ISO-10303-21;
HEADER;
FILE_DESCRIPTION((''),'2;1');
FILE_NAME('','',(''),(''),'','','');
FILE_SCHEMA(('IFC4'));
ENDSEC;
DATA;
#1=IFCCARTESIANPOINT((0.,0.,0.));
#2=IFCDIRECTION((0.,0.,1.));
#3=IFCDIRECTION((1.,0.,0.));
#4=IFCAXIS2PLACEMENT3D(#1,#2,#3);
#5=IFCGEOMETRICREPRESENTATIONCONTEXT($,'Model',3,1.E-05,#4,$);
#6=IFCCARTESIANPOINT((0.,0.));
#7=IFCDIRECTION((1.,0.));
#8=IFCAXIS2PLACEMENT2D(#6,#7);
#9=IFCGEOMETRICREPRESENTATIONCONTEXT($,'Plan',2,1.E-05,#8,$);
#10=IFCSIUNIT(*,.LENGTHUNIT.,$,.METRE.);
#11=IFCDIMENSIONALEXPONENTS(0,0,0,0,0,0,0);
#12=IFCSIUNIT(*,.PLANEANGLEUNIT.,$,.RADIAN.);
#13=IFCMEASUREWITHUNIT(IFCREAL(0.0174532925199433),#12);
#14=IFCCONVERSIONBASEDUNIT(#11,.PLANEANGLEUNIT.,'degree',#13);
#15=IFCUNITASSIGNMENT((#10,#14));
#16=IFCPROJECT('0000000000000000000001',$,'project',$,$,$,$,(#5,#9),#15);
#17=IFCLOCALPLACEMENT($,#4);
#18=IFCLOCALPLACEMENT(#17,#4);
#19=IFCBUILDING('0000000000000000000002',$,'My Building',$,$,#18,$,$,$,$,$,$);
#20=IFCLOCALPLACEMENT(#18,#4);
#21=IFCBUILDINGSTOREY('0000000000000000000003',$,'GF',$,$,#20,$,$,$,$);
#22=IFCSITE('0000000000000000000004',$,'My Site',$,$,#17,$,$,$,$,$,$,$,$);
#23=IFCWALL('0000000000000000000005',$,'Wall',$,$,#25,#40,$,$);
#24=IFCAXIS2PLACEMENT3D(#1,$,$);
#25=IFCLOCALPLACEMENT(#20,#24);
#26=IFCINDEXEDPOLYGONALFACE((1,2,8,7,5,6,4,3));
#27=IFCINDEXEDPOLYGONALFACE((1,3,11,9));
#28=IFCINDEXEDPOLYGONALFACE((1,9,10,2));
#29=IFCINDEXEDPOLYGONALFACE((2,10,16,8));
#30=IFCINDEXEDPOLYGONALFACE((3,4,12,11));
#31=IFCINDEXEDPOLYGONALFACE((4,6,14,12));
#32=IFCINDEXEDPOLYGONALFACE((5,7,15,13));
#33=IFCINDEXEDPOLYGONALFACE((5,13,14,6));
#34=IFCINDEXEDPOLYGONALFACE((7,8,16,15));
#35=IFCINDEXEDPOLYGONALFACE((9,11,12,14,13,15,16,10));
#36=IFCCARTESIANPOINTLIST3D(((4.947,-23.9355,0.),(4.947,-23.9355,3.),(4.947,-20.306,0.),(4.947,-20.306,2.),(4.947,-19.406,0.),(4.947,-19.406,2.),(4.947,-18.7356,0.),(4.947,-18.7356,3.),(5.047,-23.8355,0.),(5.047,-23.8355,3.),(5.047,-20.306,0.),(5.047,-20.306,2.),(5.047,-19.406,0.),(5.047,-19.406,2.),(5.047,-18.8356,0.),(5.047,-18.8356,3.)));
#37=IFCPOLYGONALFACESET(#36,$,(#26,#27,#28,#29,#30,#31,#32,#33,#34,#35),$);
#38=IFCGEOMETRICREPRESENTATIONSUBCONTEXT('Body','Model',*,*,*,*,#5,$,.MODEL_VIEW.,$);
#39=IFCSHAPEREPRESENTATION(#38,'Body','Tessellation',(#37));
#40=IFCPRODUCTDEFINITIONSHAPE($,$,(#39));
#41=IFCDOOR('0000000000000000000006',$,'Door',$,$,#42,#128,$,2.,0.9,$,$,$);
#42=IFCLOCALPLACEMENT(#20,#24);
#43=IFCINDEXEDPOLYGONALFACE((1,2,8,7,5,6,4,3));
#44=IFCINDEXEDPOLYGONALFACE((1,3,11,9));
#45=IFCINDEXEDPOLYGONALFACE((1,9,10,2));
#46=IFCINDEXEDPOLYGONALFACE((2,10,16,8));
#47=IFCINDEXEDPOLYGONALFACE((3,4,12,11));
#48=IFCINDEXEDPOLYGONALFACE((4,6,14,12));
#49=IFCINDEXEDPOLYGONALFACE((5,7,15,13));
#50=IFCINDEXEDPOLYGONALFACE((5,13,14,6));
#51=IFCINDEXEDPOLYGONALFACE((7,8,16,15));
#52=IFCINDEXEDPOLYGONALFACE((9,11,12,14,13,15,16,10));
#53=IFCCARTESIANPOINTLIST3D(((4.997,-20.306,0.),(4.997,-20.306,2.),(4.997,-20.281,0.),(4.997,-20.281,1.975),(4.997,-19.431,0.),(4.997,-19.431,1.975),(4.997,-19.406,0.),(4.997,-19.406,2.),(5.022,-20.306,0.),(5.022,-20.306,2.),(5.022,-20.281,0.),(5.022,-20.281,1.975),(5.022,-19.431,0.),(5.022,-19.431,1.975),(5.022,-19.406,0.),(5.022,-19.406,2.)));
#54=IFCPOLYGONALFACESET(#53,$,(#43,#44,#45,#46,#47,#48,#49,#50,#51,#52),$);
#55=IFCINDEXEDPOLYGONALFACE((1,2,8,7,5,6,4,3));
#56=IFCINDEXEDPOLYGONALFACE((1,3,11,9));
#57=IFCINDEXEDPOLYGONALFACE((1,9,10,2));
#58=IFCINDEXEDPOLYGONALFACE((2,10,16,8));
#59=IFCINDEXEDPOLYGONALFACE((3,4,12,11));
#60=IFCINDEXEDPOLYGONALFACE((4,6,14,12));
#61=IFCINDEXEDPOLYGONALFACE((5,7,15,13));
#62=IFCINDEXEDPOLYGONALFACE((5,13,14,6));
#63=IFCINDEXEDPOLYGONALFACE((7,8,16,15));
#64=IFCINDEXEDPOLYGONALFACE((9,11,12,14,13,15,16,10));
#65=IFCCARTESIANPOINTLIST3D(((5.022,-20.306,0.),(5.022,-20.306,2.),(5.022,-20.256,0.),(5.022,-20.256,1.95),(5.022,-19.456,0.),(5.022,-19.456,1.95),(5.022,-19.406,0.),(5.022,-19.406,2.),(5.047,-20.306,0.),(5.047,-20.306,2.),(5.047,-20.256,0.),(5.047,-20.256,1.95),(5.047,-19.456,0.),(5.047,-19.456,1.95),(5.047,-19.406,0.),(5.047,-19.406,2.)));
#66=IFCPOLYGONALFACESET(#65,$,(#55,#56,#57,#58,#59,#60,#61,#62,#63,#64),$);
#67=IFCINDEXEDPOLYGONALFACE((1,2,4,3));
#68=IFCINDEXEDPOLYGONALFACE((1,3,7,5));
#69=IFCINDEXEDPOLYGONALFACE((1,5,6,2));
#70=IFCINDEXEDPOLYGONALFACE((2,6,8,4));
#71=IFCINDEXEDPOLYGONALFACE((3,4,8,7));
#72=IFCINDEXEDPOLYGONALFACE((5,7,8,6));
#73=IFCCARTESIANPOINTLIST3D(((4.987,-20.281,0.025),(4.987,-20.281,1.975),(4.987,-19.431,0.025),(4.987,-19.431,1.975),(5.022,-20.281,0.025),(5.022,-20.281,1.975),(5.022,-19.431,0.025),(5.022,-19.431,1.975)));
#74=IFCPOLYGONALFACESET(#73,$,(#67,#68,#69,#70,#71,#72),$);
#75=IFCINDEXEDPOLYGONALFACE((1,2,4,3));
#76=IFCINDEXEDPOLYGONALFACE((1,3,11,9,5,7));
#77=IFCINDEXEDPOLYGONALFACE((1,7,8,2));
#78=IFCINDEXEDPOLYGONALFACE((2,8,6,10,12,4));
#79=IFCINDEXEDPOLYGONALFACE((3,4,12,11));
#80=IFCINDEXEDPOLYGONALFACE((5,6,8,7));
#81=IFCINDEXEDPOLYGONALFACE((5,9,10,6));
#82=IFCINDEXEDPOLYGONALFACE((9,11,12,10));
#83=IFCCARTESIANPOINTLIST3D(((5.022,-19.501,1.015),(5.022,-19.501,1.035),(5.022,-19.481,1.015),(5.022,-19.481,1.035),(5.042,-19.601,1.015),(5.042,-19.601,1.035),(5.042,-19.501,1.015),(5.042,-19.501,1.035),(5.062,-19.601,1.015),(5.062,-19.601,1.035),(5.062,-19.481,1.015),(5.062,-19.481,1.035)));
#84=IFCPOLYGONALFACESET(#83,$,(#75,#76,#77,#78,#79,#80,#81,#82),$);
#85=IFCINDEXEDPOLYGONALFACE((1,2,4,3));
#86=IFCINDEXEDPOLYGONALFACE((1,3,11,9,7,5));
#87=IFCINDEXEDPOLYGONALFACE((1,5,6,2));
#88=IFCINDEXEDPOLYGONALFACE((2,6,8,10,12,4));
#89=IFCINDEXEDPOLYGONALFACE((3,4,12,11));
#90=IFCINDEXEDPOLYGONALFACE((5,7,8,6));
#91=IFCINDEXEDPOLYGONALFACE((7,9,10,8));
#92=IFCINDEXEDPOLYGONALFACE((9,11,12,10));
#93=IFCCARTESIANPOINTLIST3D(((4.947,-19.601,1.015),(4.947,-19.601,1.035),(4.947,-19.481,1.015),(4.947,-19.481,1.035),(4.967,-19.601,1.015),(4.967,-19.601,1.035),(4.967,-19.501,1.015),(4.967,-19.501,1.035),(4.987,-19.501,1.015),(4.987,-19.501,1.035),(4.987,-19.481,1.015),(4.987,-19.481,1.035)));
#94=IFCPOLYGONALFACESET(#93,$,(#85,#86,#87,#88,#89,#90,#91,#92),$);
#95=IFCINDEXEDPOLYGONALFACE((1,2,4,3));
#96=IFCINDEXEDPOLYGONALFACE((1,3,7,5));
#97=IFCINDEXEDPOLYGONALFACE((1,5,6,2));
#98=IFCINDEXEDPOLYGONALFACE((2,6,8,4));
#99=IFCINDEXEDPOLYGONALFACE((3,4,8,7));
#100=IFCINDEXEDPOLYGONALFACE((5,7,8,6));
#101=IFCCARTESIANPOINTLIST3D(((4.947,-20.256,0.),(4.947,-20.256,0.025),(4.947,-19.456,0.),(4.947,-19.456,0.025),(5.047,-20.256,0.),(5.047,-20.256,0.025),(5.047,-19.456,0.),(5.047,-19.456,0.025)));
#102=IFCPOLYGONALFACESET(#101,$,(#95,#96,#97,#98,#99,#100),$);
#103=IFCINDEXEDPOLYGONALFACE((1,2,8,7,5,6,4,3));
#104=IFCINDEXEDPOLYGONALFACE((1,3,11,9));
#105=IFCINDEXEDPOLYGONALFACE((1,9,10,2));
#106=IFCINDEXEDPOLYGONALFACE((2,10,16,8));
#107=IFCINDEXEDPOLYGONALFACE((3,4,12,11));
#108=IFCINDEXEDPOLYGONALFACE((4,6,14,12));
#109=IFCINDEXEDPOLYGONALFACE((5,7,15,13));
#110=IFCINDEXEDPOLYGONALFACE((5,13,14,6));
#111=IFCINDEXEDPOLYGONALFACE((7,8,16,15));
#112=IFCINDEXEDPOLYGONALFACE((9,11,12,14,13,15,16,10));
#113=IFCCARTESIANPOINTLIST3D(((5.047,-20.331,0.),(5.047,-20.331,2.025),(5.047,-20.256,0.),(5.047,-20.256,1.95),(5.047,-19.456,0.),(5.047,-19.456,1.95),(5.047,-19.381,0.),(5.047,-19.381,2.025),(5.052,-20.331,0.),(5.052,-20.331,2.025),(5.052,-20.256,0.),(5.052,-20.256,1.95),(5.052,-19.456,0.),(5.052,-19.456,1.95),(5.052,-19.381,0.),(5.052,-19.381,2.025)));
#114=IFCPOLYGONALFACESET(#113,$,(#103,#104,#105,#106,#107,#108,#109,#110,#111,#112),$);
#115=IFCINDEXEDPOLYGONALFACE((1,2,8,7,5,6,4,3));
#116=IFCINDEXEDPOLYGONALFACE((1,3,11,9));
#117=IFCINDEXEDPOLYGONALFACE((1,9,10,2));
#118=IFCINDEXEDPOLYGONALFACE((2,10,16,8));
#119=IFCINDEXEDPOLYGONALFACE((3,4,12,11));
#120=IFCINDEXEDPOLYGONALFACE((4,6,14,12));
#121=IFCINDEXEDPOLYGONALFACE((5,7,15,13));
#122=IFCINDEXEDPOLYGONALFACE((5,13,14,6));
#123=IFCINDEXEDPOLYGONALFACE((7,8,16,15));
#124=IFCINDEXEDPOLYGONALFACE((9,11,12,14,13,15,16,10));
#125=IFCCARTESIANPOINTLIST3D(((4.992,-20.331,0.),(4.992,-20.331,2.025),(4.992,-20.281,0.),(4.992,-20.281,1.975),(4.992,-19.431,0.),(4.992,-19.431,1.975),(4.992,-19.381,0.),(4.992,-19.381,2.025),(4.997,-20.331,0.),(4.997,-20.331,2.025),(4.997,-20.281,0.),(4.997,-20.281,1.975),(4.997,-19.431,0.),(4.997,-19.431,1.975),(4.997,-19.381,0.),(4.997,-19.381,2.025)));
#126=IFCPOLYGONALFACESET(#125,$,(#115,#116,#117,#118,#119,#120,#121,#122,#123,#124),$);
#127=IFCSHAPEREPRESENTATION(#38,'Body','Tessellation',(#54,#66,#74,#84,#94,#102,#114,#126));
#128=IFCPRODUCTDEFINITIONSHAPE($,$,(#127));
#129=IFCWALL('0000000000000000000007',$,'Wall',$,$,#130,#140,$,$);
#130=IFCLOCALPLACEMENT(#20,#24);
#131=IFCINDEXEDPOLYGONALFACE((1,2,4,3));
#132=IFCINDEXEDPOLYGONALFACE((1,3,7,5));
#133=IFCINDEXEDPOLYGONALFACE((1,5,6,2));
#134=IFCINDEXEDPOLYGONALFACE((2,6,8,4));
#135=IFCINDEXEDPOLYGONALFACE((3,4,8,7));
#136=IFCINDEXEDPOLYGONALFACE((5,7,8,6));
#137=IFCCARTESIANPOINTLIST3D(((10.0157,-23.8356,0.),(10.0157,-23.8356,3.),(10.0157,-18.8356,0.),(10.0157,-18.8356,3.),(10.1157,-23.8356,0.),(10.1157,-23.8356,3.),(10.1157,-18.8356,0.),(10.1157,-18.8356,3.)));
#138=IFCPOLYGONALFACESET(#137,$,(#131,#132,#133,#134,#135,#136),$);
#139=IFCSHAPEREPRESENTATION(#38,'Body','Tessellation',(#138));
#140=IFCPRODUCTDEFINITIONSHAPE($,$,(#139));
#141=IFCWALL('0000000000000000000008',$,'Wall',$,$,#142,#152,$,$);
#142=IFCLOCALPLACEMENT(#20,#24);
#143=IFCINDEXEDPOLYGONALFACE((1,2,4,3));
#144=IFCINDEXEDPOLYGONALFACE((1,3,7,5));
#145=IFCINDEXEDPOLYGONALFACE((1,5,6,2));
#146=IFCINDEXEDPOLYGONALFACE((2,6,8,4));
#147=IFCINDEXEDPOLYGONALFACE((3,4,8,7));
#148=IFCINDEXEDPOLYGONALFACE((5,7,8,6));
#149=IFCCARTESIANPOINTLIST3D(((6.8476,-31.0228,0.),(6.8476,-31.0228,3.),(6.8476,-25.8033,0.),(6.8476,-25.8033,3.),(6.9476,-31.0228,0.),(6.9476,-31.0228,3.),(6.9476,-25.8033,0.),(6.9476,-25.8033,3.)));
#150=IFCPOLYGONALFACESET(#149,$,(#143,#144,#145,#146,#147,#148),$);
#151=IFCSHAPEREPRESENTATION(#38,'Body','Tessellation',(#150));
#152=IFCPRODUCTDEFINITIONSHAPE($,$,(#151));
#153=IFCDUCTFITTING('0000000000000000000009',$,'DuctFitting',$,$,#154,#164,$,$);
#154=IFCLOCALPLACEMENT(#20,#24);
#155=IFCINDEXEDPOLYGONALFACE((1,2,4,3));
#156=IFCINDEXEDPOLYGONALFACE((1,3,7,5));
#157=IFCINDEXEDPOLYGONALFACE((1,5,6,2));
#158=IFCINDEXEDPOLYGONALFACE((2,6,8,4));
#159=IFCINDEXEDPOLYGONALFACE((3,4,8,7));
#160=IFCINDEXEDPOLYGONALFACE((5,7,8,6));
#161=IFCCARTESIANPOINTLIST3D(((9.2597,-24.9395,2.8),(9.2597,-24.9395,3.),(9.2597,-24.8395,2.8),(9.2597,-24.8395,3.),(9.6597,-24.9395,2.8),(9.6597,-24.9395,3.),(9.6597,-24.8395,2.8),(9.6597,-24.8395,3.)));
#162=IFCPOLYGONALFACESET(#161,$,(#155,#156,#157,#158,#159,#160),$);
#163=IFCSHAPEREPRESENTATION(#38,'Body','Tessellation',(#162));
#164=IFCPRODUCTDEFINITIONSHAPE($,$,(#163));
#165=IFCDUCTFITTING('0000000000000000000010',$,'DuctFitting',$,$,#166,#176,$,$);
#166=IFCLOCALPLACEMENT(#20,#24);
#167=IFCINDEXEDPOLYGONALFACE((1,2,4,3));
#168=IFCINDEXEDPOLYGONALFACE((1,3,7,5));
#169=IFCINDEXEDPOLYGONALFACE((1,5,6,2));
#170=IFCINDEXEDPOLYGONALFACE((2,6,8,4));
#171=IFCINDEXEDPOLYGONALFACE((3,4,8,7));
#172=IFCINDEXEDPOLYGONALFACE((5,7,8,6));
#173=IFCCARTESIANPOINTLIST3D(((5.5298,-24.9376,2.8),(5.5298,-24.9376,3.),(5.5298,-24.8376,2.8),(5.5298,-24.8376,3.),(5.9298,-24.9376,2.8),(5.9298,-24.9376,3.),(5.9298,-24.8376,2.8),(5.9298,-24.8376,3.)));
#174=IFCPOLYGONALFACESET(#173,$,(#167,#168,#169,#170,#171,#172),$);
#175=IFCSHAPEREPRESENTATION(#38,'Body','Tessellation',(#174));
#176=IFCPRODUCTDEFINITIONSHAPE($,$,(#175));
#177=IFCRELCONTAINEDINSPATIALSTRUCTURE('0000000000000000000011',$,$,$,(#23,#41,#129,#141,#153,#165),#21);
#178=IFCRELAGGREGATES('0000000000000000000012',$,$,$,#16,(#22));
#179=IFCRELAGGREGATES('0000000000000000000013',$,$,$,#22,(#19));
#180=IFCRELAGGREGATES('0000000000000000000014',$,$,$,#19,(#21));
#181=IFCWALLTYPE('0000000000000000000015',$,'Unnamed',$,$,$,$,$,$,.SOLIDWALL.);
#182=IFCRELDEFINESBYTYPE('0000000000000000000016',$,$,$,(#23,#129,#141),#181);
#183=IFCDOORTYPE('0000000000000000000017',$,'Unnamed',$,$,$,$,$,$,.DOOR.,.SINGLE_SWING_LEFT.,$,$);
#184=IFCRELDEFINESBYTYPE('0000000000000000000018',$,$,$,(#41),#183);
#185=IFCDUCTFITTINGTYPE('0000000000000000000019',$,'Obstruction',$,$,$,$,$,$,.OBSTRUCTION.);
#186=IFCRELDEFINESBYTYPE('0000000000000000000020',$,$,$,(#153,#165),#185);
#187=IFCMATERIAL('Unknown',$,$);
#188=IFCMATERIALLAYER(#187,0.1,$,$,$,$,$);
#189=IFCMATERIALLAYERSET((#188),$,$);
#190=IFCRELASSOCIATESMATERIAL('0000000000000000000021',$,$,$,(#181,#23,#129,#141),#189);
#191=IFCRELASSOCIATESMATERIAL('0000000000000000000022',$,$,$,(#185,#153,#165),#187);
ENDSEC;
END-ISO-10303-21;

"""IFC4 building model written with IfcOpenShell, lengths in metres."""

from ifc_helpers import new_model, entity, si_unit, converted_unit, frame, origin_with_axes, origin_2d_with_axis, place, context, subcontext, project, spatial, line, indexed_curve, rectangle, outline, extrude, shape, source, transform, mapped, material, layer, layer_set, layer_usage, material_profile, profile_set, profile_usage, type_object, type_shapes, element, fill, save


model = new_model("IFC4")

# Units and contexts
model_context = context("Model", 3, precision=1e-05, world=origin_with_axes())
plan_context = context("Plan", 2, precision=1e-05, world=origin_2d_with_axis())
body_context_1 = subcontext(model_context, "Body", "Model", "MODEL_VIEW")
body_context_2 = subcontext(plan_context, "Body", "Plan", "PLAN_VIEW")
ifc_project = project(units=[si_unit("LENGTHUNIT", "METRE"), converted_unit("PLANEANGLEUNIT", "degree", entity("IfcReal", 0.0174532925199433), si_unit("PLANEANGLEUNIT", "RADIAN"), dimensions=[0, 0, 0, 0, 0, 0, 0])], contexts=[model_context, plan_context])

# Site, building, storey
site_placement = place(None, origin_with_axes())
site = spatial("IfcSite", under=ifc_project, at=site_placement, Name="My Site")
building_placement = place(site_placement, origin_with_axes())
building = spatial("IfcBuilding", under=site, at=building_placement, Name="My Building")
storey_placement = place(building_placement, origin_with_axes())
storey = spatial("IfcBuildingStorey", under=building, at=storey_placement, Name="GF")

# Shared definitions
ifc_material = material(Name="Unknown")

# Shared definitions
ifc_layer_1 = layer(ifc_material, 0.1)
ifc_layer_set_1 = layer_set([ifc_layer_1])
wall_type = type_object("IfcWallType", Name="Unnamed", PredefinedType="SOLIDWALL", material=ifc_layer_set_1)

# Shared definitions
shared_shape_1 = source(origin_with_axes(), body_context_1, "Body", "SweptSolid", [
    extrude(outline(indexed_curve([(0.0, 0.0), (0.9, 0.0), (0.9, 2.0), (0.0, 2.0)], segments=[line(1, 2, 3, 4, 1)])), frame((0.0, -0.6, 0.0), z_axis=(0.0, -1.0, 0.0), x_axis=(1.0, 0.0, 0.0)), (0.0, 0.0, -1.0), 1.2),
])
door_type = type_object("IfcDoorType", Name="Unnamed", OperationType="SINGLE_SWING_LEFT", PredefinedType="DOOR")
shared_shape_2 = source(origin_with_axes(), body_context_1, "Body", "SweptSolid", [
    extrude(outline(indexed_curve([(0.0, 0.0), (0.0, 2.0), (0.9, 2.0), (0.9, 0.0), (0.875, 0.0), (0.875, 1.975), (0.025, 1.975), (0.025, 0.0)], segments=[line(1, 2, 3, 4, 5, 6, 7, 8, 1)])), frame((0.0, 0.025, 0.0), z_axis=(0.0, -1.0, 0.0), x_axis=(1.0, 0.0, 0.0)), (0.0, 0.0, -1.0), 0.025),
    extrude(outline(indexed_curve([(0.0, 0.0), (0.0, 2.0), (0.9, 2.0), (0.9, 0.0), (0.85, 0.0), (0.85, 1.95), (0.05, 1.95), (0.05, 0.0)], segments=[line(1, 2, 3, 4, 5, 6, 7, 8, 1)])), frame((0.0, 0.0, 0.0), z_axis=(0.0, -1.0, 0.0), x_axis=(1.0, 0.0, 0.0)), (0.0, 0.0, -1.0), 0.025),
    extrude(outline(indexed_curve([(0.0, 0.0), (0.85, 0.0), (0.85, 0.035), (0.0, 0.035)], segments=[line(1, 2, 3, 4, 1)])), frame((0.025, 0.025, 0.025), z_axis=(0.0, 0.0, 1.0), x_axis=(1.0, 0.0, 0.0)), (0.0, 0.0, 1.0), 1.95),
    extrude(outline(indexed_curve([(0.0, 0.0), (0.0, -0.04), (-0.12, -0.04), (-0.12, -0.02), (-0.02, -0.02), (-0.02, 0.0)], segments=[line(1, 2, 3, 4, 5, 6, 1)])), frame((0.825, 0.025, 1.015), z_axis=(0.0, 0.0, 1.0), x_axis=(1.0, 0.0, 0.0)), (0.0, 0.0, 1.0), 0.02),
    extrude(outline(indexed_curve([(0.0, 0.0), (0.0, 0.04), (-0.12, 0.04), (-0.12, 0.02), (-0.02, 0.02), (-0.02, 0.0)], segments=[line(1, 2, 3, 4, 5, 6, 1)])), frame((0.825, 0.06, 1.015), z_axis=(0.0, 0.0, 1.0), x_axis=(1.0, 0.0, 0.0)), (0.0, 0.0, 1.0), 0.02),
    extrude(outline(indexed_curve([(0.0, 0.0), (0.8, 0.0), (0.8, 0.1), (0.0, 0.1)], segments=[line(1, 2, 3, 4, 1)])), frame((0.05, 0.0, 0.0), z_axis=(0.0, 0.0, 1.0), x_axis=(1.0, 0.0, 0.0)), (0.0, 0.0, 1.0), 0.025),
    extrude(outline(indexed_curve([(0.0, 0.0), (0.0, 2.025), (0.95, 2.025), (0.95, 0.0), (0.875, 0.0), (0.875, 1.95), (0.075, 1.95), (0.075, 0.0)], segments=[line(1, 2, 3, 4, 5, 6, 7, 8, 1)])), frame((-0.025, -0.005, 0.0), z_axis=(0.0, -1.0, 0.0), x_axis=(1.0, 0.0, 0.0)), (0.0, 0.0, -1.0), 0.005),
    extrude(outline(indexed_curve([(0.0, 0.0), (0.0, 2.025), (0.95, 2.025), (0.95, 0.0), (0.9, 0.0), (0.9, 1.975), (0.05, 1.975), (0.05, 0.0)], segments=[line(1, 2, 3, 4, 5, 6, 7, 8, 1)])), frame((-0.025, 0.05, 0.0), z_axis=(0.0, -1.0, 0.0), x_axis=(1.0, 0.0, 0.0)), (0.0, 0.0, -1.0), 0.005),
])
shared_shape_3 = source(origin_with_axes(), body_context_2, "Body", "Curve2D", [
    entity("IfcIndexedPolyCurve", entity("IfcCartesianPointList2D", [[0.0, 0.0], [0.0, 0.05], [0.025, 0.05], [0.025, 0.025], [0.05, 0.025], [0.05, 0.0]]), [entity("IfcLineIndex", [1, 2, 3, 4, 5, 6, 1])]),
    entity("IfcIndexedPolyCurve", entity("IfcCartesianPointList2D", [[0.9, 0.0], [0.9, 0.05], [0.875, 0.05], [0.875, 0.025], [0.85, 0.025], [0.85, 0.0]]), [entity("IfcLineIndex", [1, 2, 3, 4, 5, 6, 1])]),
    entity("IfcTrimmedCurve", entity("IfcEllipse", entity("IfcAxis2Placement2D", entity("IfcCartesianPoint", [0.06, 0.05]), entity("IfcDirection", [1.0, 0.0])), 0.815, 0.85), [entity("IfcCartesianPoint", [0.875, 0.05])], [entity("IfcCartesianPoint", [0.06, 0.9])], True, "CARTESIAN"),
    entity("IfcIndexedPolyCurve", entity("IfcCartesianPointList2D", [[0.025, 0.05], [0.06, 0.05], [0.06, 0.9], [0.025, 0.9]]), [entity("IfcLineIndex", [1, 2, 3, 4, 1])]),
])
type_shapes(door_type, [shared_shape_2, shared_shape_3])

# Wall, opening, door
ifc_layer_usage_1 = layer_usage(ifc_layer_set_1, "AXIS2", "POSITIVE", 0.0)
wall_1_placement = place(storey_placement, frame((5.047, -23.8355, 0.0), z_axis=(0.0, 0.0, 1.0), x_axis=(0.0, 1.0, 0.0)))
wall_1 = element("IfcWall", 1, at=wall_1_placement, inside=storey, type_object=wall_type, material=ifc_layer_usage_1, Name="Wall", context=body_context_1, shape_type="SweptSolid", body=[
    extrude(outline(indexed_curve([(0.0, 0.0), (-0.1, 0.1), (5.1, 0.1), (5.0, 0.0)], segments=[line(1, 2, 3, 4, 1)])), origin_with_axes(), (0.0, 0.0, 1.0), 3.0),
])
opening_1_placement = place(wall_1_placement, frame((3.5295, 0.0, 0.0), z_axis=(0.0, 0.0, 1.0), x_axis=(1.0, 0.0, 0.0)))
opening_1 = element("IfcOpeningElement", 2, at=opening_1_placement, cuts=wall_1, PredefinedType="OPENING", context=body_context_1, shape_type="MappedRepresentation", body=[
    mapped(shared_shape_1, transform((0.0, 0.0, 0.0), x_axis=(1.0, 0.0, 0.0), y_axis=(0.0, 1.0, 0.0), z_axis=(0.0, 0.0, 1.0), scale=1.0)),
])
door_1_placement = place(opening_1_placement, frame((0.0, 0.0, 0.0), z_axis=(0.0, 0.0, 1.0), x_axis=(1.0, 0.0, 0.0)))
door_1 = element("IfcDoor", 3, at=door_1_placement, inside=storey, type_object=door_type, Name="Door", OverallHeight=2.0, OverallWidth=0.9, shapes=[
    shape(body_context_1, "Body", "MappedRepresentation", [mapped(shared_shape_2, transform((0.0, 0.0, 0.0), x_axis=(1.0, 0.0, 0.0), y_axis=(0.0, 1.0, 0.0), z_axis=(0.0, 0.0, 1.0), scale=1.0))]),
    shape(body_context_2, "Body", "MappedRepresentation", [mapped(shared_shape_3, transform((0.0, 0.0, 0.0), x_axis=(1.0, 0.0, 0.0), y_axis=(0.0, 1.0, 0.0), z_axis=(0.0, 0.0, 1.0), scale=1.0))]),
])
fill(opening_1, door_1)

# Walls
ifc_layer_usage_2 = layer_usage(ifc_layer_set_1, "AXIS2", "POSITIVE", 0.0)
wall_2_placement = place(storey_placement, frame((10.0157, -18.8356, 0.0), z_axis=(0.0, 0.0, 1.0), x_axis=(0.0, -1.0, 0.0)))
element("IfcWall", 4, at=wall_2_placement, inside=storey, type_object=wall_type, material=ifc_layer_usage_2, Name="Wall", context=body_context_1, shape_type="SweptSolid", body=[
    extrude(outline(indexed_curve([(0.0, 0.0), (0.0, 0.1), (5.0, 0.1), (5.0, 0.0)], segments=[line(1, 2, 3, 4, 1)])), origin_with_axes(), (0.0, 0.0, 1.0), 3.0),
])
ifc_layer_usage_3 = layer_usage(ifc_layer_set_1, "AXIS2", "POSITIVE", 0.0)
wall_3_placement = place(storey_placement, frame((6.8476, -25.8033, 0.0), z_axis=(0.0, 0.0, 1.0), x_axis=(0.0, -1.0, 0.0)))
element("IfcWall", 5, at=wall_3_placement, inside=storey, type_object=wall_type, material=ifc_layer_usage_3, Name="Wall", context=body_context_1, shape_type="SweptSolid", body=[
    extrude(outline(indexed_curve([(0.0, 0.0), (0.0, 0.1), (5.2195, 0.1), (5.2195, 0.0)], segments=[line(1, 2, 3, 4, 1)])), origin_with_axes(), (0.0, 0.0, 1.0), 3.0),
])

# Duct fittings
ifc_material_profile = material_profile(ifc_material, rectangle(XDim=0.4, YDim=0.2))
ifc_profile_set = profile_set([ifc_material_profile])
ifc_profile_usage_1 = profile_usage(ifc_profile_set, cardinal=5)
duct_fitting_type = type_object("IfcDuctFittingType", Name="Obstruction", PredefinedType="OBSTRUCTION", material=ifc_profile_set)
duct_fitting_1_placement = place(storey_placement, frame((9.4597, -24.8395, 2.9), z_axis=(0.0, -1.0, 0.0), x_axis=(1.0, 0.0, 0.0)))
element("IfcDuctFitting", 6, at=duct_fitting_1_placement, inside=storey, type_object=duct_fitting_type, material=ifc_profile_usage_1, Name="DuctFitting", context=body_context_1, shape_type="SweptSolid", body=[
    extrude(rectangle(XDim=0.4, YDim=0.2), origin_with_axes(), (0.0, 0.0, 1.0), 0.1),
])
ifc_profile_usage_2 = profile_usage(ifc_profile_set, cardinal=5)
duct_fitting_2_placement = place(storey_placement, frame((5.7298, -24.8376, 2.9), z_axis=(0.0, -1.0, 0.0), x_axis=(1.0, 0.0, 0.0)))
element("IfcDuctFitting", 7, at=duct_fitting_2_placement, inside=storey, type_object=duct_fitting_type, material=ifc_profile_usage_2, Name="DuctFitting", context=body_context_1, shape_type="SweptSolid", body=[
    extrude(rectangle(XDim=0.4, YDim=0.2), origin_with_axes(), (0.0, 0.0, 1.0), 0.1),
])

save(model, "model.ifc")
